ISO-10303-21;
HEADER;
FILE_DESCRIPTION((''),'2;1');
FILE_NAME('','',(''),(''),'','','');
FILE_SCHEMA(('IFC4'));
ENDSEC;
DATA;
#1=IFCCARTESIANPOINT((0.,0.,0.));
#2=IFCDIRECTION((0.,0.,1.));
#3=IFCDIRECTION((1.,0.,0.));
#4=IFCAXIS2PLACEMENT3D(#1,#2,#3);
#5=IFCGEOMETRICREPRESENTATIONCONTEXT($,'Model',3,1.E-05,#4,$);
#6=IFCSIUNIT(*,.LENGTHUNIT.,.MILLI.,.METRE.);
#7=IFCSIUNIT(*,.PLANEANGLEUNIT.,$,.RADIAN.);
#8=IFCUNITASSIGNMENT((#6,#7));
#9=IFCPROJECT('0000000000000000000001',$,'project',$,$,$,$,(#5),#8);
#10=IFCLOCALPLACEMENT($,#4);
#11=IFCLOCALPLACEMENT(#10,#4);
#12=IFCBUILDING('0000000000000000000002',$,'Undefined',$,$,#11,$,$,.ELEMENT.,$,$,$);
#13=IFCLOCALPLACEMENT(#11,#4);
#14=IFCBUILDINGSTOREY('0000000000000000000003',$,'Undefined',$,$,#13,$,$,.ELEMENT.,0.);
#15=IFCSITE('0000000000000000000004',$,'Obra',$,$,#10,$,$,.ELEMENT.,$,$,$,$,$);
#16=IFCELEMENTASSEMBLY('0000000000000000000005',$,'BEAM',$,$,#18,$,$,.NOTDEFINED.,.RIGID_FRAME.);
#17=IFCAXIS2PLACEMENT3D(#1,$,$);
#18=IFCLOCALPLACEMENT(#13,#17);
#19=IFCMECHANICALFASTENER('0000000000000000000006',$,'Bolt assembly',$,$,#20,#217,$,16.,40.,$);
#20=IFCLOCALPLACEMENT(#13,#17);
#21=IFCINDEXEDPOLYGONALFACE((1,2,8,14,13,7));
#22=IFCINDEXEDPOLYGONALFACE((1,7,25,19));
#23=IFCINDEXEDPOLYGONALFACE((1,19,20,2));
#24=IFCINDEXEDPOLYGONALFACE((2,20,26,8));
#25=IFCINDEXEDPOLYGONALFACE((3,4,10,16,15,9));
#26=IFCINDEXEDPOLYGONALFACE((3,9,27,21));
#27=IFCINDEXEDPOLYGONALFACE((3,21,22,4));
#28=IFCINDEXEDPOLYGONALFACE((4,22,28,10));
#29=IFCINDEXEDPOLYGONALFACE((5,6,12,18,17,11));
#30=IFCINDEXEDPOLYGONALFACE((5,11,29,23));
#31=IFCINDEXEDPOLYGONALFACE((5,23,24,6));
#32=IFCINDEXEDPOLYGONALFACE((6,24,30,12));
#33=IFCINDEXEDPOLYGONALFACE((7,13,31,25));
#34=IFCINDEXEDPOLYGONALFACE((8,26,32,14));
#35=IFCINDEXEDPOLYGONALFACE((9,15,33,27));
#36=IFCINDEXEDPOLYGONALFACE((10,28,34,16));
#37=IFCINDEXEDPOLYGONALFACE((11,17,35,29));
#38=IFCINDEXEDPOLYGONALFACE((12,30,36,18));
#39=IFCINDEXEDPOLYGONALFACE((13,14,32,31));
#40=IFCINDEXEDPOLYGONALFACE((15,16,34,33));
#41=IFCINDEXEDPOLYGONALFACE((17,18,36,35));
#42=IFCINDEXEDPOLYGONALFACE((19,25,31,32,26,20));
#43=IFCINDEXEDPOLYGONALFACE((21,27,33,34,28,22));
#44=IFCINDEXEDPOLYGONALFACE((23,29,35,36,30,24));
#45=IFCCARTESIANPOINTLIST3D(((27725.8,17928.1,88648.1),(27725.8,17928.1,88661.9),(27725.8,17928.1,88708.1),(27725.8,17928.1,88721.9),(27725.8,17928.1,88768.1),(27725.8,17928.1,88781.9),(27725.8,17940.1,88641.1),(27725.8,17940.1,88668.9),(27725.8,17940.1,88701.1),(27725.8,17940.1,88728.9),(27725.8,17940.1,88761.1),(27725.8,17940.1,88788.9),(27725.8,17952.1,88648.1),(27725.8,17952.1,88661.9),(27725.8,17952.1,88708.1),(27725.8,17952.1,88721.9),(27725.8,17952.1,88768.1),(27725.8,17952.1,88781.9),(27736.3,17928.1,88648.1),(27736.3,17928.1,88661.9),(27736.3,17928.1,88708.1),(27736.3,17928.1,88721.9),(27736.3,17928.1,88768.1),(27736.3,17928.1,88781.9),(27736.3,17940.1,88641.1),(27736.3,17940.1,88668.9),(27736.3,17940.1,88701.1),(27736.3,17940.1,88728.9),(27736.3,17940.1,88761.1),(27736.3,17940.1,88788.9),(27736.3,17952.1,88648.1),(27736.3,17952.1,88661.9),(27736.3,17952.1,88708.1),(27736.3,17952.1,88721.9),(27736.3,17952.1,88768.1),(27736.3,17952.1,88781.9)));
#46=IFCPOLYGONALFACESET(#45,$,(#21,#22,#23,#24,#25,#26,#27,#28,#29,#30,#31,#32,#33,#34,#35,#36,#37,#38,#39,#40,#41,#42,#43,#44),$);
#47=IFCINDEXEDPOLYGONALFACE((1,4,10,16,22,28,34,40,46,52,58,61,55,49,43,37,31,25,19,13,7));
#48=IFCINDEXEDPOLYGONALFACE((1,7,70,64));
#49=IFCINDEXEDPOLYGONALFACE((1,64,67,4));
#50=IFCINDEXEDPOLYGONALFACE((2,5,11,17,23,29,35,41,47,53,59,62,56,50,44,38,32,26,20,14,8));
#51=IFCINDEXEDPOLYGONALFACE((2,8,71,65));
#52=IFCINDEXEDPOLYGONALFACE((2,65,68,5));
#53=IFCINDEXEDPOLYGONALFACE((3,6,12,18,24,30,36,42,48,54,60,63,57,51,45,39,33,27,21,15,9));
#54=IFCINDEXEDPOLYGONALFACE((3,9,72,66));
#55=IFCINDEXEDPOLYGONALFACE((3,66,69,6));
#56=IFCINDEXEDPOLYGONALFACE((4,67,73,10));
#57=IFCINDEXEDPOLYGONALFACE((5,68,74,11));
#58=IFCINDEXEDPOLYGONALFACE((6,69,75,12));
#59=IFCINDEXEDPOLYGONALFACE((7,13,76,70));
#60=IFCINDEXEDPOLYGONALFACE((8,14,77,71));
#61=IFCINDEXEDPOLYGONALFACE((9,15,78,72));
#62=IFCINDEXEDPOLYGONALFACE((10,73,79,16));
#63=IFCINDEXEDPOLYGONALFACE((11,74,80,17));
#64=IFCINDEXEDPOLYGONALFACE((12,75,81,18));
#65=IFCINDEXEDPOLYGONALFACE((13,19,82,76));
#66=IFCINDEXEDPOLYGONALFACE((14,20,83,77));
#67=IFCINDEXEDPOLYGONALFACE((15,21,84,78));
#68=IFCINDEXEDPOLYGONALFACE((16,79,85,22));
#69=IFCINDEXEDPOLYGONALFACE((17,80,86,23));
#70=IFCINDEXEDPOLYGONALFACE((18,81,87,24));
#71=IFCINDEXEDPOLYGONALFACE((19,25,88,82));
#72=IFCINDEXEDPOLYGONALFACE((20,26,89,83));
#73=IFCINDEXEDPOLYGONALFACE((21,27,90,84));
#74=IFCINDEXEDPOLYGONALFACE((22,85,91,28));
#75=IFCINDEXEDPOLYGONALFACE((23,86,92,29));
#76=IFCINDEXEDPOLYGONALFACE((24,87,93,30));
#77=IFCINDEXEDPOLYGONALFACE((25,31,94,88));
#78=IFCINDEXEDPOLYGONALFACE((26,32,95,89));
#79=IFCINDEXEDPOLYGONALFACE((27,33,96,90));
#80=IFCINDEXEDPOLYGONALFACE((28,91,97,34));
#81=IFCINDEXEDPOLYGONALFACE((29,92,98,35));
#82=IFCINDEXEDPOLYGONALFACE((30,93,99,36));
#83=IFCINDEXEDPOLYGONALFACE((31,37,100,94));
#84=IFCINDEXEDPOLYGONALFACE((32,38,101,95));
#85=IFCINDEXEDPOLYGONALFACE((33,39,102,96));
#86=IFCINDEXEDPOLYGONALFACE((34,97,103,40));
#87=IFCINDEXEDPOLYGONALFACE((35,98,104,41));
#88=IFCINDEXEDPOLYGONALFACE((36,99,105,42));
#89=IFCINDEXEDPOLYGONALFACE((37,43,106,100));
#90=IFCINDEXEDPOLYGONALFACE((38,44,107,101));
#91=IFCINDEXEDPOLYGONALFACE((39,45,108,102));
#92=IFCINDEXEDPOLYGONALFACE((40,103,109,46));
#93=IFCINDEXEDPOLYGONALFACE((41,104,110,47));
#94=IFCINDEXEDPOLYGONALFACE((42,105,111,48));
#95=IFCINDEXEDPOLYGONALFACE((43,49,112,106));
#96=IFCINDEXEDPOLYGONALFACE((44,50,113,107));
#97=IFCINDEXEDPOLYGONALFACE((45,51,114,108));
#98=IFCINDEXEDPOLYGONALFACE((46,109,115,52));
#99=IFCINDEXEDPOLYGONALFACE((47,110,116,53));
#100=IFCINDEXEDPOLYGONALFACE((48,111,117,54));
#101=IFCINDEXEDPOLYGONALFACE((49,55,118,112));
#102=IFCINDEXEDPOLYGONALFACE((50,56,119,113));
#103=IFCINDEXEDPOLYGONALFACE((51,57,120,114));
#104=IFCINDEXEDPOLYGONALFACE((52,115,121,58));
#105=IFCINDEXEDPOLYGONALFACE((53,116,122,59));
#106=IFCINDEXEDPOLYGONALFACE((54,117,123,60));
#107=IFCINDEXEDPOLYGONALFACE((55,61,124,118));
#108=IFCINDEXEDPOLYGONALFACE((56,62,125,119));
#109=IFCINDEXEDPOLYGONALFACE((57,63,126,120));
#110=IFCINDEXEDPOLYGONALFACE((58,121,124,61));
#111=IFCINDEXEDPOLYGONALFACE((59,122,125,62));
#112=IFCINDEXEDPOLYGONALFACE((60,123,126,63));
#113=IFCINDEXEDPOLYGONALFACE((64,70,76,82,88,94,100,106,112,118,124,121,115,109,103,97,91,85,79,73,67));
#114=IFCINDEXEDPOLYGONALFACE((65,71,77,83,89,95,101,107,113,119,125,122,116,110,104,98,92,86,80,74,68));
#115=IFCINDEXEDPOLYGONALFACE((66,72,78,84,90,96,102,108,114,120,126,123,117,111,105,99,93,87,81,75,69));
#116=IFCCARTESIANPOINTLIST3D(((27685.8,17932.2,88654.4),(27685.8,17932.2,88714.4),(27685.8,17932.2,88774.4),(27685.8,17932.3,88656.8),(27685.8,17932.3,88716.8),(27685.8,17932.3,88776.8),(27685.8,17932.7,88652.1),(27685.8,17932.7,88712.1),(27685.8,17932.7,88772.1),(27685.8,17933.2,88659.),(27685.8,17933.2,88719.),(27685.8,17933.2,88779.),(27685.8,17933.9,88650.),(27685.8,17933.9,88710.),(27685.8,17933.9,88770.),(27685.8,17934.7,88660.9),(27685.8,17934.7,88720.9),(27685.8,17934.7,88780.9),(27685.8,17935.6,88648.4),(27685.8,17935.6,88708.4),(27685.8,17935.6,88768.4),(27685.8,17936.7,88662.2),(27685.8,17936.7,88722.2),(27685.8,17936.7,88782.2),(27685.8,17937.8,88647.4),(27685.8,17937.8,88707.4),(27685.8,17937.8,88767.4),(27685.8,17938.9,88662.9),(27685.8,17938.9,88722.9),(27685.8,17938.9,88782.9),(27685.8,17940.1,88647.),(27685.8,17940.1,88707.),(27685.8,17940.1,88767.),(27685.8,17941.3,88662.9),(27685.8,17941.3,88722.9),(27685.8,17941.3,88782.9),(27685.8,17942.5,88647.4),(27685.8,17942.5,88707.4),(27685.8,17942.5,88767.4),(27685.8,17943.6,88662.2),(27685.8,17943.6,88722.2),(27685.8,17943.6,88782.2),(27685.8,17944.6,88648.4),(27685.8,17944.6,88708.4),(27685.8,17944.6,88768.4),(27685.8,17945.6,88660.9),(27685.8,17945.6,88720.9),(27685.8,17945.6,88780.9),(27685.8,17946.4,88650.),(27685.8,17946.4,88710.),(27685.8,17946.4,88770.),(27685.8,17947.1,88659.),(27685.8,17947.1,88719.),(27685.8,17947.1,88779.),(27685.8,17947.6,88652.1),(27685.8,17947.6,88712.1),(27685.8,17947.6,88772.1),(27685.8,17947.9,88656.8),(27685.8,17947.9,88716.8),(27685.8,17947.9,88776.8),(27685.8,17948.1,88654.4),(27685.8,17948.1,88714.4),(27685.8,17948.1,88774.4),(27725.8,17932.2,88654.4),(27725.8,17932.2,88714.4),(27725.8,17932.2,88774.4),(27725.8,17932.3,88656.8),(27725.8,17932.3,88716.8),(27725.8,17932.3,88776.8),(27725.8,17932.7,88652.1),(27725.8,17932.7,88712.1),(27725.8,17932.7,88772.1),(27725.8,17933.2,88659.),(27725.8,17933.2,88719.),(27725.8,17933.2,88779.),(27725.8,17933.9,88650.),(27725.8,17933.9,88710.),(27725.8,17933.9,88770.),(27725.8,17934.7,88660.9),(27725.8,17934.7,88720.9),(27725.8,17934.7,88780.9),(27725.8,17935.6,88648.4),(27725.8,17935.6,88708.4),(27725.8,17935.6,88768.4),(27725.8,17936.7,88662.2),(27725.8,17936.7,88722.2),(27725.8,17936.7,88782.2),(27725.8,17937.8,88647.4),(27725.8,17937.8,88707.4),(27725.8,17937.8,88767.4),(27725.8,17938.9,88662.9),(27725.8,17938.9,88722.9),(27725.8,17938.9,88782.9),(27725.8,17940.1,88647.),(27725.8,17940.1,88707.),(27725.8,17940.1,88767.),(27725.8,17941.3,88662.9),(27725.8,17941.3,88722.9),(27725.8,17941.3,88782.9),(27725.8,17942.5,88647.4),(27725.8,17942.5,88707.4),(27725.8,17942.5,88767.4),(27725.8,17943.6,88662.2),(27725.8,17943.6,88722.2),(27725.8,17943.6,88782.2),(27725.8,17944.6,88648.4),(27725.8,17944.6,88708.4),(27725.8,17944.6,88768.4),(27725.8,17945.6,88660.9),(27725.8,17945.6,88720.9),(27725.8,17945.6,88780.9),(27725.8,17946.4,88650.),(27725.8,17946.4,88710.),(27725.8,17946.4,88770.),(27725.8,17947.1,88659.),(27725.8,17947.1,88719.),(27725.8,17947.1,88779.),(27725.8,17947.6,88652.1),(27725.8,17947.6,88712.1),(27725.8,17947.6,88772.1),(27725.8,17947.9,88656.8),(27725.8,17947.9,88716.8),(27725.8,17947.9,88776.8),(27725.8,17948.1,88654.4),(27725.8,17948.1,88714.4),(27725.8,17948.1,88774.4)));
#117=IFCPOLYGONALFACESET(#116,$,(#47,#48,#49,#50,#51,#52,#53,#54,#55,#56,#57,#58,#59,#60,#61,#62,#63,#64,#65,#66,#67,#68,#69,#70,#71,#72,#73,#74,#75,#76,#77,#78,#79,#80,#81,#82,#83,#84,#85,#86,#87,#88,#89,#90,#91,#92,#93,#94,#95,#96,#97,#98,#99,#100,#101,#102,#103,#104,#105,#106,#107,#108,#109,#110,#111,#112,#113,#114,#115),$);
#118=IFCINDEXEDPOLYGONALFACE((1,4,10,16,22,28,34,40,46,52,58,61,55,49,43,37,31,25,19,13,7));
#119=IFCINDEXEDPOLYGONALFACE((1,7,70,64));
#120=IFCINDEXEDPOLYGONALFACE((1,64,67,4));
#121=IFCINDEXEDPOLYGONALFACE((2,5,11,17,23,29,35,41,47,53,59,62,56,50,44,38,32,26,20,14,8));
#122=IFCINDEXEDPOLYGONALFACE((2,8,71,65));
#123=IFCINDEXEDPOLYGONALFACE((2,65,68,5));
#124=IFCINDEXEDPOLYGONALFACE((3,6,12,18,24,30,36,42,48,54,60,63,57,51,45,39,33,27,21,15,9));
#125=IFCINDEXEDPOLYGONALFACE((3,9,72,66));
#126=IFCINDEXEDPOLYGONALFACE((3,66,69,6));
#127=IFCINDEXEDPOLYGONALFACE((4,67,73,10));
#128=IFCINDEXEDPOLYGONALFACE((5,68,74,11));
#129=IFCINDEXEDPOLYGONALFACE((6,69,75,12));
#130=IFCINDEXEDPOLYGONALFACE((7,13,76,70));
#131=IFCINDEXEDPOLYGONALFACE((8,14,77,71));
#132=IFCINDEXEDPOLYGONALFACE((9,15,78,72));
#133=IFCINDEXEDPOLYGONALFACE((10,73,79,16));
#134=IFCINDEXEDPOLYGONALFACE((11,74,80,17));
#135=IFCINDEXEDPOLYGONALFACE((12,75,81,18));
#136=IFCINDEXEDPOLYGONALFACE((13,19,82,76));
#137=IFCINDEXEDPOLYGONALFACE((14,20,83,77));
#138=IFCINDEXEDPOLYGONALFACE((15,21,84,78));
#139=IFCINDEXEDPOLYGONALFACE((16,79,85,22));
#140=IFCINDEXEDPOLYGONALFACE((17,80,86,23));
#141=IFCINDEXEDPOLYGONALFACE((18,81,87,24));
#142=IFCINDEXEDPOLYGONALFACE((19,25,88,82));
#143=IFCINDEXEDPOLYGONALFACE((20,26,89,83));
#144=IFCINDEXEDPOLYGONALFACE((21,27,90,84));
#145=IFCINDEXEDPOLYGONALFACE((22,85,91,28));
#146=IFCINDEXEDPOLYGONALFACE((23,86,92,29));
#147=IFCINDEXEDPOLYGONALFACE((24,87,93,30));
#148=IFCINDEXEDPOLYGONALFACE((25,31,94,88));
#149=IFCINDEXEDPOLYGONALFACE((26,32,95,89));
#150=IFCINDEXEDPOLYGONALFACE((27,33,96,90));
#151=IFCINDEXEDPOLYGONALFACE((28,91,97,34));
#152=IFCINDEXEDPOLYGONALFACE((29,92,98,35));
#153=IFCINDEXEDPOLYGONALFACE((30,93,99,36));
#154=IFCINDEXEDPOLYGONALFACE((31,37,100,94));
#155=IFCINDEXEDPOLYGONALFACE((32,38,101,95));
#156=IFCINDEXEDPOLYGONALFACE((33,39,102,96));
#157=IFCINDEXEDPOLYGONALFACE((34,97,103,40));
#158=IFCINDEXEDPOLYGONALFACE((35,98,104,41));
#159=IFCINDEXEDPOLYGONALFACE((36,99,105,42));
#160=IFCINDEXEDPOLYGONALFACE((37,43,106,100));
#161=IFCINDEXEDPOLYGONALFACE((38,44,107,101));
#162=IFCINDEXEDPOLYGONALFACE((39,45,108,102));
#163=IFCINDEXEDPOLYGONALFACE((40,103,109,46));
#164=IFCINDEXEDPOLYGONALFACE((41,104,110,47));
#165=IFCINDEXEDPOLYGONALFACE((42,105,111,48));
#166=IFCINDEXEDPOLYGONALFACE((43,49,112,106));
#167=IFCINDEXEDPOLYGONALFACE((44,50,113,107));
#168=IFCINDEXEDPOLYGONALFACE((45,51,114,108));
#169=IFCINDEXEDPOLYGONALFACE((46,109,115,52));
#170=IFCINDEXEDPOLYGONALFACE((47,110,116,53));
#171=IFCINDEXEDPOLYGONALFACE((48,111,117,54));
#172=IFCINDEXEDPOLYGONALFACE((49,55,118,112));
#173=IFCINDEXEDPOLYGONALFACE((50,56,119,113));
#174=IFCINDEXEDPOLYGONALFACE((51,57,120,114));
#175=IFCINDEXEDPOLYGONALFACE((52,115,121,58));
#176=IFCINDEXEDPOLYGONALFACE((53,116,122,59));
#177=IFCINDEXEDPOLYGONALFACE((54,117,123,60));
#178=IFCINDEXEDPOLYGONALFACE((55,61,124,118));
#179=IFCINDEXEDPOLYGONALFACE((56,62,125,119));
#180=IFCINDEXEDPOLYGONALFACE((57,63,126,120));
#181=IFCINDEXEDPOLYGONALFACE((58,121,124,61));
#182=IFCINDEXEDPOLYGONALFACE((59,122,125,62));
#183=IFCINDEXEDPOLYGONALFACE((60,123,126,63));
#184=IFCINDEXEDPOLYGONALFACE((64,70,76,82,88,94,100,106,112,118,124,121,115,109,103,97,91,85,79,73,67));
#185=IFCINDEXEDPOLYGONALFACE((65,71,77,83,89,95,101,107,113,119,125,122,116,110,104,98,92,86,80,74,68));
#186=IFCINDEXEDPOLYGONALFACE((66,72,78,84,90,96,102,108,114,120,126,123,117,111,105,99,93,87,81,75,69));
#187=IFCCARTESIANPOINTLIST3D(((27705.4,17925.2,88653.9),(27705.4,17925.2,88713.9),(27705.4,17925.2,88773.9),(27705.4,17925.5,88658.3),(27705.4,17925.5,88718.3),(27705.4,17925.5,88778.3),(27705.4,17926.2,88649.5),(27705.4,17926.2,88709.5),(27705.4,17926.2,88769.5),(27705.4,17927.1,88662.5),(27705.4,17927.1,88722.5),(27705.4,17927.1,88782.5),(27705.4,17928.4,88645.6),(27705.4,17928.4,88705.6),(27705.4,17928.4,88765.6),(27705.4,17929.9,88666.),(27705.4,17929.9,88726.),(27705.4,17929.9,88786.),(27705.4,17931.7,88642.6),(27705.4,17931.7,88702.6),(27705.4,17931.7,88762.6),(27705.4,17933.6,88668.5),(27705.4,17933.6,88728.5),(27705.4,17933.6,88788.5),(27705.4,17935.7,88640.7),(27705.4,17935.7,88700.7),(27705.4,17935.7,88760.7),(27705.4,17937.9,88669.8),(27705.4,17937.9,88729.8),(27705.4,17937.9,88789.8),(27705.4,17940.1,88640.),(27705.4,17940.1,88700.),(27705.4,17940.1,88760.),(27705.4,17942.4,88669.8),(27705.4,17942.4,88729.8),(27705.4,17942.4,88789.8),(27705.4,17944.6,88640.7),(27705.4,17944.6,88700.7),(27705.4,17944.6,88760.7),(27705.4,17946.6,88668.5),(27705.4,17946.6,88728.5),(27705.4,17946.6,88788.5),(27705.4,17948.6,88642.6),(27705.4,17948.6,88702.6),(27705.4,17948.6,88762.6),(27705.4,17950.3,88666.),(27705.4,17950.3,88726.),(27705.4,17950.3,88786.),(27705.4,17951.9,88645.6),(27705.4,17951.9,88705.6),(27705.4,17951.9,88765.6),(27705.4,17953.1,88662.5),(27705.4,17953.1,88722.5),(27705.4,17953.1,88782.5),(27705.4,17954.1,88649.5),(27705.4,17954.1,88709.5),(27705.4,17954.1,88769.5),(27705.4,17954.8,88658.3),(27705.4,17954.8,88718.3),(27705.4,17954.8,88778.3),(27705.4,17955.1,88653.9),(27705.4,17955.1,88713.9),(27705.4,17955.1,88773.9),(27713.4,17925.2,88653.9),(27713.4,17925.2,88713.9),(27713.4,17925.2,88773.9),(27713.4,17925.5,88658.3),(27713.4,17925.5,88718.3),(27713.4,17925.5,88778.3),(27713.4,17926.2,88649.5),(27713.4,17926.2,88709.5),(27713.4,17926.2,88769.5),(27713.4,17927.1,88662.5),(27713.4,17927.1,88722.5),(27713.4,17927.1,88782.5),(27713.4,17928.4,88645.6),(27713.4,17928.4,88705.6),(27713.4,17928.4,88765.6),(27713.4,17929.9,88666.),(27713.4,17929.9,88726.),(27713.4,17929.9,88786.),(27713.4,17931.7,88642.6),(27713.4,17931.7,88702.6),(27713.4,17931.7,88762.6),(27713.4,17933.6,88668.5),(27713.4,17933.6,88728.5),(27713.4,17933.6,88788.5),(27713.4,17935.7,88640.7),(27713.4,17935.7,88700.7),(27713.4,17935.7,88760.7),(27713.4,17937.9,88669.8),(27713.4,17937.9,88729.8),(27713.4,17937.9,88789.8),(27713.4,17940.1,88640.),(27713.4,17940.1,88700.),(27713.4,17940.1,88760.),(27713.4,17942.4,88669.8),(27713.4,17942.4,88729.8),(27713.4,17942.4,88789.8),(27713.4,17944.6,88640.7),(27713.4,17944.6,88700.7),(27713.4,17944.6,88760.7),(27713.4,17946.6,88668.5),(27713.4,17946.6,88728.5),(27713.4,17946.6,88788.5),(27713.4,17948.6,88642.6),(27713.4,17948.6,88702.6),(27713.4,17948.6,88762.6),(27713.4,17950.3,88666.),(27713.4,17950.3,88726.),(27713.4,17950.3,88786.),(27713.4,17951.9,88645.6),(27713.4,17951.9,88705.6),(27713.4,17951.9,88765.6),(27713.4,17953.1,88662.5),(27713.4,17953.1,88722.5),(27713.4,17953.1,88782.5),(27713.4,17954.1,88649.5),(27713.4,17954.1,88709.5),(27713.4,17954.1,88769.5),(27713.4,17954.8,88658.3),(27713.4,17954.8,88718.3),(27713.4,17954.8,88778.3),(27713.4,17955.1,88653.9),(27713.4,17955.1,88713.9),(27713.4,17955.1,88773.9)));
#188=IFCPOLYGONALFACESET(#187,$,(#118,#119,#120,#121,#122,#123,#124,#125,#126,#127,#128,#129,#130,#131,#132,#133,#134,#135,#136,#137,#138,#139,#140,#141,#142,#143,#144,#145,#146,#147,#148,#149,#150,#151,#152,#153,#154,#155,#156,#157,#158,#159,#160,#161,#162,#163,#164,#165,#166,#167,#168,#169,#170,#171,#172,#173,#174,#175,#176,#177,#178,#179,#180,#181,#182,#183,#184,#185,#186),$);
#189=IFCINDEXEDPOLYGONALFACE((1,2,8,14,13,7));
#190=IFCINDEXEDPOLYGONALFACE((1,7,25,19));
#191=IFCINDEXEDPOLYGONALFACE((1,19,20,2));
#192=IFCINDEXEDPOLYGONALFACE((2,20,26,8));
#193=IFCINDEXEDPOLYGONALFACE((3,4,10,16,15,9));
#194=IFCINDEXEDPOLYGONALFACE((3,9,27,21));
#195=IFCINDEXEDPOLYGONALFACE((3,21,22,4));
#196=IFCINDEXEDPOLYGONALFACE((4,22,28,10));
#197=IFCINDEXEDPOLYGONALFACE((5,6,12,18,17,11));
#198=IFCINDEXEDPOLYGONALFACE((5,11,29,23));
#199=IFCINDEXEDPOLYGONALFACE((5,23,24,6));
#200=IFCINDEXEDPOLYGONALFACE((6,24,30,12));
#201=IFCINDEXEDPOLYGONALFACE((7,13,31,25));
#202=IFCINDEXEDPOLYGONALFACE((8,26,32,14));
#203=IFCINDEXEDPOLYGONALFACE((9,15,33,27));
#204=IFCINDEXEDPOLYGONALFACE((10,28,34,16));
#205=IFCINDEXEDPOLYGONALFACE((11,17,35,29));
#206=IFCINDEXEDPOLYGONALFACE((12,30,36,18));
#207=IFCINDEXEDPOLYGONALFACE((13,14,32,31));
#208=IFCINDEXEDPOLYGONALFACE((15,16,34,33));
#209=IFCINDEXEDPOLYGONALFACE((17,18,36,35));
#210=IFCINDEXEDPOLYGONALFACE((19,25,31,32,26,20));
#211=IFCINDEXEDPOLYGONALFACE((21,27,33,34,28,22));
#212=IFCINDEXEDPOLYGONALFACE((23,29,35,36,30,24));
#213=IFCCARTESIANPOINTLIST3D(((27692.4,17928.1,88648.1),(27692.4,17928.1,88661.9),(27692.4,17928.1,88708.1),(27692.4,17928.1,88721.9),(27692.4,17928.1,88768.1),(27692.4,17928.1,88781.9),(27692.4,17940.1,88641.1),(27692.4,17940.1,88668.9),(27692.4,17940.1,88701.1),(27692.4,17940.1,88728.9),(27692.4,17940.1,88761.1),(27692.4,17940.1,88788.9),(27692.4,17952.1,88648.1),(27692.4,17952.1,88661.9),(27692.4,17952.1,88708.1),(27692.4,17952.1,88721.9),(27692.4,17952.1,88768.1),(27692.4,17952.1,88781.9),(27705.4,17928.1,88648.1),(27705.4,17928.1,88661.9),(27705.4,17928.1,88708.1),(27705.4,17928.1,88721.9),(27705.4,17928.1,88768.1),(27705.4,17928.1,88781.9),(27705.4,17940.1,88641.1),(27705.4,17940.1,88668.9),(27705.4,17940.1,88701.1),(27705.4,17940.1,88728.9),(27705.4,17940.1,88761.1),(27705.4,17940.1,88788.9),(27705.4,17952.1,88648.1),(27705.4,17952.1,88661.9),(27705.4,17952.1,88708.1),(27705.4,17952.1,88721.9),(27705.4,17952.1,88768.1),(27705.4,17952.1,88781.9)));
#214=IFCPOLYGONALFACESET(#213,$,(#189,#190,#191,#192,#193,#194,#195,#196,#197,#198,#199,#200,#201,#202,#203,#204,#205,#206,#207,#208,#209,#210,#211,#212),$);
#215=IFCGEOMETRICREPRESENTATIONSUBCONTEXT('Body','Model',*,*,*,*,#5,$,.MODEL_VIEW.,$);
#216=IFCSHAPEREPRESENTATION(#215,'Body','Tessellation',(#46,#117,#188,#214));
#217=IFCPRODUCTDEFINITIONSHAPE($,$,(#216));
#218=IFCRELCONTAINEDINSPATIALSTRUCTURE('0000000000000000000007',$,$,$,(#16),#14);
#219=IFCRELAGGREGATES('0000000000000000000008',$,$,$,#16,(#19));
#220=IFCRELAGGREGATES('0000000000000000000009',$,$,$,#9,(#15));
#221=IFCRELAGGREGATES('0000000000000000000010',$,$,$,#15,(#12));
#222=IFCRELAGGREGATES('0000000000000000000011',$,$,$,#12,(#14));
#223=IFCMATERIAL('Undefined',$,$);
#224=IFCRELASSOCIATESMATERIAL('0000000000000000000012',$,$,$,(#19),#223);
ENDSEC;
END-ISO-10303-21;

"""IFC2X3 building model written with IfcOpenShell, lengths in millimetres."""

from ifc_helpers import new_model, si_unit, frame, origin_with_axes, origin_2d_with_axis, place, context, subcontext, project, spatial, polyline, circle, outline, extrude, source, transform, mapped, material, element, aggregate, save


model = new_model("IFC2X3")

# Units and contexts
model_context = context("Model", 3, precision=1e-05, world=origin_with_axes())
body_context = subcontext(model_context, "Body", "Model", "MODEL_VIEW")
ifc_project = project(units=[si_unit("LENGTHUNIT", "METRE", prefix="MILLI"), si_unit("PLANEANGLEUNIT", "RADIAN")], contexts=[model_context])

# Site, building, storey
site_placement = place(None, origin_with_axes())
site = spatial("IfcSite", under=ifc_project, at=site_placement, Name="Obra", CompositionType="ELEMENT")
building_placement = place(site_placement, origin_with_axes())
building = spatial("IfcBuilding", under=site, at=building_placement, Name="Undefined", CompositionType="ELEMENT")
storey_placement = place(building_placement, origin_with_axes())
storey = spatial("IfcBuildingStorey", under=building, at=storey_placement, Name="Undefined", CompositionType="ELEMENT", Elevation=0.0)

# Element assembly, mechanical fastener
ifc_material_1 = material(Name="Undefined")
assembly_1_placement = place(storey_placement, origin_with_axes())
assembly_1 = element("IfcElementAssembly", 1, at=assembly_1_placement, inside=storey, Name="BEAM", AssemblyPlace="NOTDEFINED", PredefinedType="RIGID_FRAME")
shared_shape_1 = source(origin_with_axes(), body_context, "Body", "SweptSolid", [
    extrude(outline(polyline([(13.9, 0.0), (6.9, 12.0), (-6.9, 12.0), (-13.9, 0.0), (-6.9, -12.0), (6.9, -12.0), (13.9, 0.0)])), frame((0.0, -19.7, 0.0), z_axis=(0.0, 1.0, 0.0), x_axis=(1.0, 0.0, 0.0)), (0.0, 0.0, 1.0), 10.6),
    extrude(circle(Radius=8.0, at=origin_2d_with_axis()), frame((0.0, -9.1, 0.0), z_axis=(0.0, 1.0, 0.0), x_axis=(1.0, 0.0, 0.0)), (0.0, 0.0, 1.0), 40.0),
    extrude(circle(Radius=15.0, at=origin_2d_with_axis()), frame((0.0, 3.3, 0.0), z_axis=(0.0, 1.0, 0.0), x_axis=(1.0, 0.0, 0.0)), (0.0, 0.0, 1.0), 8.0),
    extrude(outline(polyline([(13.9, 0.0), (6.9, 12.0), (-6.9, 12.0), (-13.9, 0.0), (-6.9, -12.0), (6.9, -12.0), (13.9, 0.0)])), frame((0.0, 11.3, 0.0), z_axis=(0.0, 1.0, 0.0), x_axis=(1.0, 0.0, 0.0)), (0.0, 0.0, 1.0), 13.0),
])
mechanical_fastener_1_placement = place(assembly_1_placement, frame((27716.7, 17890.1, 88835.0), z_axis=(0.0, 1.0, 0.0), x_axis=(0.0, 0.0, -1.0)))
mechanical_fastener_1 = element("IfcMechanicalFastener", 2, at=mechanical_fastener_1_placement, material=ifc_material_1, Name="Bolt assembly", NominalDiameter=16.0, NominalLength=40.0, context=body_context, shape_type="MappedRepresentation", body=[
    mapped(shared_shape_1, transform((60.0, 0.0, 50.0))),
    mapped(shared_shape_1, transform((120.0, 0.0, 50.0))),
    mapped(shared_shape_1, transform((180.0, 0.0, 50.0))),
])

aggregate(assembly_1, [mechanical_fastener_1])

save(model, "model.ifc")
